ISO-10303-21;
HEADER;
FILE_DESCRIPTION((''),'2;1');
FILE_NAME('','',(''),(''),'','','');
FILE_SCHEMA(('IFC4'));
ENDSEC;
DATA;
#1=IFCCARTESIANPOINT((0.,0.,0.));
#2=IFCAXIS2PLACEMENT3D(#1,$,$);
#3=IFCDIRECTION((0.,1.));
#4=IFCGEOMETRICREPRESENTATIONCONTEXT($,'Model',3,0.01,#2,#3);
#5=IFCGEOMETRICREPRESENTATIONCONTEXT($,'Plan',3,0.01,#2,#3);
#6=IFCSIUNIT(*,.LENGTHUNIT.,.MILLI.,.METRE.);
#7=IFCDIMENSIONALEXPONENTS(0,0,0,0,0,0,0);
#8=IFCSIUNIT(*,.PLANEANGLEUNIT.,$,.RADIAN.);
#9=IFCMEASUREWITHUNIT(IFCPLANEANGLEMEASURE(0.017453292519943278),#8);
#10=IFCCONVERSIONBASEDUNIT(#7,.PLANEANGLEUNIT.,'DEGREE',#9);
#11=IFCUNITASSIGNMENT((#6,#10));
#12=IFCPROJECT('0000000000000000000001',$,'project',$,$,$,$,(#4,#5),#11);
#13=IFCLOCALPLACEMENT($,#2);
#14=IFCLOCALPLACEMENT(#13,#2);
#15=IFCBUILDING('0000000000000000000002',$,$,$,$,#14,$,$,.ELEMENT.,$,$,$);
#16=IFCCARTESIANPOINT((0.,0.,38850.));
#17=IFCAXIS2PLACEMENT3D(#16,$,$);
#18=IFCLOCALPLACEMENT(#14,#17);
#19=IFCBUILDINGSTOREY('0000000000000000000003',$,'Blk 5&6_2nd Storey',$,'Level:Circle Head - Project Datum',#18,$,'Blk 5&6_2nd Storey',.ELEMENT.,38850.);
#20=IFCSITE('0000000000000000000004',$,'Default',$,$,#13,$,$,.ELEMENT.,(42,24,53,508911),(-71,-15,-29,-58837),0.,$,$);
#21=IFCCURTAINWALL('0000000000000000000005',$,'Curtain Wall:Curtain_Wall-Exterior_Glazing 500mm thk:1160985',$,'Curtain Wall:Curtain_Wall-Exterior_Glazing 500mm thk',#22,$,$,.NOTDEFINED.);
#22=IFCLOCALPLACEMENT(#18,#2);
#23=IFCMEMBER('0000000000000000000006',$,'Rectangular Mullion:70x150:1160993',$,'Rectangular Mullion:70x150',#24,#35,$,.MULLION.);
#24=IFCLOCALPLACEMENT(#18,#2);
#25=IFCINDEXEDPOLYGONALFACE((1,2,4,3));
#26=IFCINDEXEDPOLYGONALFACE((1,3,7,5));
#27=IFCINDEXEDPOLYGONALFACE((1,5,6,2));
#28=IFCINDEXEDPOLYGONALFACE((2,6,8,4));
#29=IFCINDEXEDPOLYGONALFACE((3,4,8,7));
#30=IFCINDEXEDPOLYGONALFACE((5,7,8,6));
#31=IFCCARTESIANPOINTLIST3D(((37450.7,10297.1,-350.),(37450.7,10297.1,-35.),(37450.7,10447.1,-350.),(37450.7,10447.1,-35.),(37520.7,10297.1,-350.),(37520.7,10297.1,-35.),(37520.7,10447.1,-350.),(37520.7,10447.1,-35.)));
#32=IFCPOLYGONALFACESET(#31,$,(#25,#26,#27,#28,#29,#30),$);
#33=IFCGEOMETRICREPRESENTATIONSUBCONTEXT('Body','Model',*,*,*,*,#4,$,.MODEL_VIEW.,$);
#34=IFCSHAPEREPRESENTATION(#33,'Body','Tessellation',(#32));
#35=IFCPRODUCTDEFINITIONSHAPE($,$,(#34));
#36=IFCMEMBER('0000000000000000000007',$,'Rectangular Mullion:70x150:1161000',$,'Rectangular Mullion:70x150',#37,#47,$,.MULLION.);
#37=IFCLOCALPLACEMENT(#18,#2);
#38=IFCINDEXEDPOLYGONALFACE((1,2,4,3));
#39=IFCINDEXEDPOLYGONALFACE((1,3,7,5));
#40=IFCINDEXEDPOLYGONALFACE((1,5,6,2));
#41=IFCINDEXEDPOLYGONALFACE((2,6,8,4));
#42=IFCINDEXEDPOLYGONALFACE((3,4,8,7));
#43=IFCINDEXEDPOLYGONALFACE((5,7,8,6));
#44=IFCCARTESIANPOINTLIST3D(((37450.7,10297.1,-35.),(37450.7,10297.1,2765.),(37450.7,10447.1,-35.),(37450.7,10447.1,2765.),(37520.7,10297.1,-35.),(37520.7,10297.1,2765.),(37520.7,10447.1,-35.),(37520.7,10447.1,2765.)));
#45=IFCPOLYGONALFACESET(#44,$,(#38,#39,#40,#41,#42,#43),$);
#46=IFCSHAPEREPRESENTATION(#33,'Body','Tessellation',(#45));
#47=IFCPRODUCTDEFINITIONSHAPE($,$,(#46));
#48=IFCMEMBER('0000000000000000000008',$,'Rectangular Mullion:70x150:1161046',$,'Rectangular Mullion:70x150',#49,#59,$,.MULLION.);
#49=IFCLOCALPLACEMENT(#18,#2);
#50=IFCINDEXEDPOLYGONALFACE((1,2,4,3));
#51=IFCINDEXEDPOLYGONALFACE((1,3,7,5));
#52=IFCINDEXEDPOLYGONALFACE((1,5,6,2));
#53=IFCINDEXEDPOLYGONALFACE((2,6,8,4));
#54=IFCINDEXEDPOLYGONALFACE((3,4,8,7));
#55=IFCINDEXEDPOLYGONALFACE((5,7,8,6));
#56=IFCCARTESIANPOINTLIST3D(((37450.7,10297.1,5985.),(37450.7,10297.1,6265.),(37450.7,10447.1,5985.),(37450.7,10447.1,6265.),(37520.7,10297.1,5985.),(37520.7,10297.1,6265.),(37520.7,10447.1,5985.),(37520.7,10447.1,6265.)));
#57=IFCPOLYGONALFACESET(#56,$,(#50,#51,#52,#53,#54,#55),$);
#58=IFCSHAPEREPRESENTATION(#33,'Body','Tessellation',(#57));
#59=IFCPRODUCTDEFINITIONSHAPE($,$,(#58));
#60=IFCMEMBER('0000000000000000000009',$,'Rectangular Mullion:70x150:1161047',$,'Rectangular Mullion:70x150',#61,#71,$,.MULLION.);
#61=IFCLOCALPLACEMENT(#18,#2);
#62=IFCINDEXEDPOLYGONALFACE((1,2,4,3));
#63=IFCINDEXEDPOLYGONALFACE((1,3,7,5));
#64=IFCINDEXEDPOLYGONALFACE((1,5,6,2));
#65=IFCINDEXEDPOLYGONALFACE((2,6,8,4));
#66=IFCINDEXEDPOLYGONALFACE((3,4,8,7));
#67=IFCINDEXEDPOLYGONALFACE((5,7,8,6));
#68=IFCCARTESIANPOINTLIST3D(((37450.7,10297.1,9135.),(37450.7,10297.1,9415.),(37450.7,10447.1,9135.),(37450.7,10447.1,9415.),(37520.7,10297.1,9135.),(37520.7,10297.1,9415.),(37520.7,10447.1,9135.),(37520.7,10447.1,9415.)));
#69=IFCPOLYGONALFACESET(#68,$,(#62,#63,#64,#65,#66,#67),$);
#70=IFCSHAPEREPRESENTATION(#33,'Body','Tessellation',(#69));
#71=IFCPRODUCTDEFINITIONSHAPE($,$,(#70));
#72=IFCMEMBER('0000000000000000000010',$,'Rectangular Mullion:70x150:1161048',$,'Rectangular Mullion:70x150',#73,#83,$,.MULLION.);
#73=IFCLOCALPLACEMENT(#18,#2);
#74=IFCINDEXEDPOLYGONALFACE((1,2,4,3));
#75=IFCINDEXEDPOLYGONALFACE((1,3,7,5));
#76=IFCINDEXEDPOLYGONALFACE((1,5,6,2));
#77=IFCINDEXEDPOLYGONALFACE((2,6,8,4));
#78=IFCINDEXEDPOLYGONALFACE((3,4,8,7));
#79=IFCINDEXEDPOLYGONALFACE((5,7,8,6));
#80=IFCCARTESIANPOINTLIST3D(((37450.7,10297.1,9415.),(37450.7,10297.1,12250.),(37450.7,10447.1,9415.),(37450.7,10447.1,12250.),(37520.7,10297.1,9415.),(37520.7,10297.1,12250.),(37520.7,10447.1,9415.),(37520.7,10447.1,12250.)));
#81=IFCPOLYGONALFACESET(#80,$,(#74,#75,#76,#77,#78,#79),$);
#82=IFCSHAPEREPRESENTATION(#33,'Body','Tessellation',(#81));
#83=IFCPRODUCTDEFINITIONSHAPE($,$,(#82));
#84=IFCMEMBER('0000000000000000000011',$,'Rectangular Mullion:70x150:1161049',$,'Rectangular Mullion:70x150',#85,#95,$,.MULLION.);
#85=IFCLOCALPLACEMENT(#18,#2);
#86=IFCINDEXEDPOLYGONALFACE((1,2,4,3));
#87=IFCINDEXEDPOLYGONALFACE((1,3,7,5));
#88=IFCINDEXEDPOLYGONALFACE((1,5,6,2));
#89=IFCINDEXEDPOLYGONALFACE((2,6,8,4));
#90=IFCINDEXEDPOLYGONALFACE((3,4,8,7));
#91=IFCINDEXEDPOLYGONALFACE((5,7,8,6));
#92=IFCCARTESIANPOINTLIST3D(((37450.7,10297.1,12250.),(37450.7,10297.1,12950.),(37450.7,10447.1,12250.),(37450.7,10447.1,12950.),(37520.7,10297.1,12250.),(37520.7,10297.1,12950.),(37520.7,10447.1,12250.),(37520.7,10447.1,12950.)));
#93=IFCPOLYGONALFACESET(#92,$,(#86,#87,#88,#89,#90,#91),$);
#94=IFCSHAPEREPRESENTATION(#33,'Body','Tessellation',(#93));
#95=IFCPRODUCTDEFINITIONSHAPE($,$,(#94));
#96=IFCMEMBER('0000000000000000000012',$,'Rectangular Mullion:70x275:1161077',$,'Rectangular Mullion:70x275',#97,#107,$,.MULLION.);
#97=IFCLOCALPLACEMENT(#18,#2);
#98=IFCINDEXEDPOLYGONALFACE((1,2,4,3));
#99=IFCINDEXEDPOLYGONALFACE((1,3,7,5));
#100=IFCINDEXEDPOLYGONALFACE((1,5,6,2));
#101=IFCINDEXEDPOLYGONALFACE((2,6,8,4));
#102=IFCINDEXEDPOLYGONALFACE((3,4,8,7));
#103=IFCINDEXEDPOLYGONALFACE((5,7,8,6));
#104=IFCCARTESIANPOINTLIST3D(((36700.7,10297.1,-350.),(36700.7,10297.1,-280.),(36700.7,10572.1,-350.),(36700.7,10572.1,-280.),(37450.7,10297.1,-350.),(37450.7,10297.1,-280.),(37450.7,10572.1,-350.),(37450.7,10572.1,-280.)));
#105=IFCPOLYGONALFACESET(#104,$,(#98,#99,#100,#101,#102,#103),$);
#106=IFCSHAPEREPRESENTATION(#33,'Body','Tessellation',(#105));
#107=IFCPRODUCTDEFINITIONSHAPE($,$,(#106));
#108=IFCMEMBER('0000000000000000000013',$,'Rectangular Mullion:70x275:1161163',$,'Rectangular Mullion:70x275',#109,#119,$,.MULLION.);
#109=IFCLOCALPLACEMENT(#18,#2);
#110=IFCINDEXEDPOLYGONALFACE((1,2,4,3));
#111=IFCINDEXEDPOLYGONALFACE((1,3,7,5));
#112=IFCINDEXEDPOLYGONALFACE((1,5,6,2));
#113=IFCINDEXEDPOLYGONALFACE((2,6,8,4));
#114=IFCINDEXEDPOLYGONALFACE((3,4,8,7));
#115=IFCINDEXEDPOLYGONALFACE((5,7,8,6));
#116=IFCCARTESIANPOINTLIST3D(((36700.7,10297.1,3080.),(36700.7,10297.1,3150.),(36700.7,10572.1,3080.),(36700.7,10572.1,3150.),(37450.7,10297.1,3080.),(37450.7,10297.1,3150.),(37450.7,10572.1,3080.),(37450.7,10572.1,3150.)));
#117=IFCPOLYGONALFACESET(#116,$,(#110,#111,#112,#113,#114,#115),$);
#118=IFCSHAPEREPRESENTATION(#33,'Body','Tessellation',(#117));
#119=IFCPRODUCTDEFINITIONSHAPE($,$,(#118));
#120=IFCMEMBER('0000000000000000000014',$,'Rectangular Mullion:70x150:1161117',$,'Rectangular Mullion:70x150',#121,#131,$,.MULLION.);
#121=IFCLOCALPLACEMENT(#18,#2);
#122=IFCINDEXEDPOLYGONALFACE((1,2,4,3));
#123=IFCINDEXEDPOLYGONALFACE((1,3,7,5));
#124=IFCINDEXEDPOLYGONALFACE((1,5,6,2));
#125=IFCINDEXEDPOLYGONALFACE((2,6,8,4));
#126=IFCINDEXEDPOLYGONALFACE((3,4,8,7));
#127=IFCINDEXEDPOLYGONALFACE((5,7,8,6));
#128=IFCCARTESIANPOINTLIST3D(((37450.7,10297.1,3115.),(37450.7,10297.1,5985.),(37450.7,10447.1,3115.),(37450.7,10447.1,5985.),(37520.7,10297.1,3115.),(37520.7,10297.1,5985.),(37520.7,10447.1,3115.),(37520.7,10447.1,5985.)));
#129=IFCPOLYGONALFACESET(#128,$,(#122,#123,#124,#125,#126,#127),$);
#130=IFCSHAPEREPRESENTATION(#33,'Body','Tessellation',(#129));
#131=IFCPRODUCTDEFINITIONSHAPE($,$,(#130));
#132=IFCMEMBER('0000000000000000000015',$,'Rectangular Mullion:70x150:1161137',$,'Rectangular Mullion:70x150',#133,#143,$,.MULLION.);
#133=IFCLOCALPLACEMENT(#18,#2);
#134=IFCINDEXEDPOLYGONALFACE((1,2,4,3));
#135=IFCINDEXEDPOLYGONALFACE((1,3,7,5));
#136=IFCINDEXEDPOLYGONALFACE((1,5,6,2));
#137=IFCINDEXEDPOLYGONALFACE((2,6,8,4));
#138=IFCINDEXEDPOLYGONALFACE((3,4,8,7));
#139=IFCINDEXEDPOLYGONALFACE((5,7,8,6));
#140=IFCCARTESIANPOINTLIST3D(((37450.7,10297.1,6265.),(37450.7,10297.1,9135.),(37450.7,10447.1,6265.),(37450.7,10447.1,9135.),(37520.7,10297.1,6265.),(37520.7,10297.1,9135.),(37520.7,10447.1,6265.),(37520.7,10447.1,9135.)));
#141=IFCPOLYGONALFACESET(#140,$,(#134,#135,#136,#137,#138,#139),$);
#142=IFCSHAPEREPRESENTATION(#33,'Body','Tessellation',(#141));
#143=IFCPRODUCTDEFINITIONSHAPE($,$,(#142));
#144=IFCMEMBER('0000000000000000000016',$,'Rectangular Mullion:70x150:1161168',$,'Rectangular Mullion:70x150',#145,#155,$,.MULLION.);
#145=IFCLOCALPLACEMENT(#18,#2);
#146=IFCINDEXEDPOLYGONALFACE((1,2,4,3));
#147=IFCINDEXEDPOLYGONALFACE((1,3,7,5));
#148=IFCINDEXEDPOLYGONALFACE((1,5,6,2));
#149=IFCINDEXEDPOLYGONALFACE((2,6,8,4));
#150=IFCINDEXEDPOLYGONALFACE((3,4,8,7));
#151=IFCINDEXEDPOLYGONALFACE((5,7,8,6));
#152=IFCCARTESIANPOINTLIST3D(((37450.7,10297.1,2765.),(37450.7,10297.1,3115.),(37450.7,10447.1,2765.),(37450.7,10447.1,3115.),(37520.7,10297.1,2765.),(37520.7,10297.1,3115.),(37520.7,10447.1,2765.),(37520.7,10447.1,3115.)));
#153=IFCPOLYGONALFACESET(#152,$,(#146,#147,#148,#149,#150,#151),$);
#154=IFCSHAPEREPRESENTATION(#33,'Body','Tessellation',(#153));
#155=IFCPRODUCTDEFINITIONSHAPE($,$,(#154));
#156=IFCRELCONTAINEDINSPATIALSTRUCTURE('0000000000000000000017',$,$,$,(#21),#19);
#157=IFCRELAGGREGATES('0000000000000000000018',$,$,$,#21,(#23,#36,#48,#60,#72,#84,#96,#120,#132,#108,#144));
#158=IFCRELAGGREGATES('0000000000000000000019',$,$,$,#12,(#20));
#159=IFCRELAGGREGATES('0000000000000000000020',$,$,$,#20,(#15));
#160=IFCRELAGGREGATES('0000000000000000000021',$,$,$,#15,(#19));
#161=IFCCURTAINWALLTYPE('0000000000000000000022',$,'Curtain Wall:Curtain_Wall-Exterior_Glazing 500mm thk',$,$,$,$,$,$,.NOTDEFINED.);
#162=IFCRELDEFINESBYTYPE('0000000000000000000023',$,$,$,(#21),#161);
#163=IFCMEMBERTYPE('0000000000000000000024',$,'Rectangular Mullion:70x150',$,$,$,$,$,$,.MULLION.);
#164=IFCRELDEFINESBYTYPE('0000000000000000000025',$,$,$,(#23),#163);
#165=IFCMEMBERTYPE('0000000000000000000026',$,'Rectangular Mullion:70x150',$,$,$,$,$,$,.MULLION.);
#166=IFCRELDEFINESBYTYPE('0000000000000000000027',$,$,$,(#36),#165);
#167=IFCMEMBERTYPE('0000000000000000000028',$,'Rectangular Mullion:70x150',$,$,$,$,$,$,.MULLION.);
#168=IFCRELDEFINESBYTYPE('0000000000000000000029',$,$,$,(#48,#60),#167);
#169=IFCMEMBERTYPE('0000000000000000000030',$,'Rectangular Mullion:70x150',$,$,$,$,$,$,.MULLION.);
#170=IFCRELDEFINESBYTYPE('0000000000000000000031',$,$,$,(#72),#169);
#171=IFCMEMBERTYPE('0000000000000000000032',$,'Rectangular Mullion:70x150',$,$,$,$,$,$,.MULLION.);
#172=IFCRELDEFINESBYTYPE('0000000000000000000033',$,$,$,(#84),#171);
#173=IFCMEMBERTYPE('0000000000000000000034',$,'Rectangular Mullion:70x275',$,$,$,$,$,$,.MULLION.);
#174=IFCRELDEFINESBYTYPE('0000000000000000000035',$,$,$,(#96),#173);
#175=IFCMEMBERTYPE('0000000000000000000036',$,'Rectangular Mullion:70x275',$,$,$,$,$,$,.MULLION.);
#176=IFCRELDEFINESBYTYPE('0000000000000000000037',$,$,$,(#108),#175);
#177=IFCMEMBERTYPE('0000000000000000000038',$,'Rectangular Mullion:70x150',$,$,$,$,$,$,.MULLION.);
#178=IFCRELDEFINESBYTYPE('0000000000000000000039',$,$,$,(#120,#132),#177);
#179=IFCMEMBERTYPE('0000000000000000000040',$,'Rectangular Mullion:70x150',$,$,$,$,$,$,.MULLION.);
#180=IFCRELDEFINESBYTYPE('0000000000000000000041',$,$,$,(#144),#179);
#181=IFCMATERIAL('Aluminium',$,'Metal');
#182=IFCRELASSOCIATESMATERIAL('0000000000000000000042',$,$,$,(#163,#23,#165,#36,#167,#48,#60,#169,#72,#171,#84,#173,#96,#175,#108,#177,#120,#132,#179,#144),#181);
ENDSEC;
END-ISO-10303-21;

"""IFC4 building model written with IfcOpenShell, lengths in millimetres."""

from ifc_helpers import new_model, entity, si_unit, converted_unit, direction, frame, origin, place, context, subcontext, project, spatial, indexed_curve, outline, extrude, source, transform, mapped, material, type_object, type_shapes, element, aggregate, save


model = new_model("IFC4")

# Units and contexts
model_context = context("Model", 3, precision=0.01, world=origin(), true_north=direction((0.0, 1.0)))
plan_context = context("Plan", 3, precision=0.01, world=origin(), true_north=direction((0.0, 1.0)))
body_context = subcontext(model_context, "Body", "Model", "MODEL_VIEW")
ifc_project = project(units=[si_unit("LENGTHUNIT", "METRE", prefix="MILLI"), converted_unit("PLANEANGLEUNIT", "DEGREE", entity("IfcPlaneAngleMeasure", 0.017453292519943278), si_unit("PLANEANGLEUNIT", "RADIAN"), dimensions=[0, 0, 0, 0, 0, 0, 0])], contexts=[model_context, plan_context])

# Site, building, storey
site_placement = place(None, origin())
site = spatial("IfcSite", under=ifc_project, at=site_placement, Name="Default", CompositionType="ELEMENT", RefLatitude=(42, 24, 53, 508911), RefLongitude=(-71, -15, -29, -58837), RefElevation=0.0)
building_placement = place(site_placement, origin())
building = spatial("IfcBuilding", under=site, at=building_placement, CompositionType="ELEMENT")
storey_placement = place(building_placement, frame((0.0, 0.0, 38850.0)))
storey = spatial("IfcBuildingStorey", under=building, at=storey_placement, Name="Blk 5&6_2nd Storey", ObjectType="Level:Circle Head - Project Datum", LongName="Blk 5&6_2nd Storey", CompositionType="ELEMENT", Elevation=38850.0)

# Curtain wall, members
curtain_wall_type = type_object("IfcCurtainWallType", Name="Curtain Wall:Curtain_Wall-Exterior_Glazing 500mm thk", PredefinedType="NOTDEFINED")
curtain_wall_placement = place(storey_placement, frame((0.0, 0.0, -38850.0)))
curtain_wall = element("IfcCurtainWall", 1, at=curtain_wall_placement, inside=storey, type_object=curtain_wall_type, Name="Curtain Wall:Curtain_Wall-Exterior_Glazing 500mm thk:1160985", ObjectType="Curtain Wall:Curtain_Wall-Exterior_Glazing 500mm thk", PredefinedType="NOTDEFINED")
ifc_material_1 = material(Name="Aluminium", Category="Metal")
member_type_1 = type_object("IfcMemberType", Name="Rectangular Mullion:70x150", PredefinedType="MULLION", material=ifc_material_1)
shared_shape_1 = source(origin(), body_context, "Body", "SweptSolid", [
    extrude(outline(indexed_curve([(-35.0, -75.0), (35.0, -75.0), (35.0, 75.0), (-35.0, 75.0), (-35.0, -75.0)], self_intersect=False)), frame((0.0, -200.0, -315.0), z_axis=(0.0, 0.0, 1.0), x_axis=(-1.0, 0.0, 0.0)), (0.0, 0.0, 1.0), 315.0),
])
type_shapes(member_type_1, [shared_shape_1])
member_1_placement = place(curtain_wall_placement, frame((37485.7, 10572.1, 38500.0), z_axis=(0.0, 0.0, -1.0), x_axis=(-1.0, 0.0, 0.0)))
member_1 = element("IfcMember", 2, at=member_1_placement, type_object=member_type_1, material=ifc_material_1, Name="Rectangular Mullion:70x150:1160993", ObjectType="Rectangular Mullion:70x150", PredefinedType="MULLION", context=body_context, shape_type="MappedRepresentation", body=[
    mapped(shared_shape_1, transform((0.0, 0.0, 0.0), scale=1.0)),
])
member_type_2 = type_object("IfcMemberType", Name="Rectangular Mullion:70x150", PredefinedType="MULLION", material=ifc_material_1)
shared_shape_2 = source(origin(), body_context, "Body", "SweptSolid", [
    extrude(outline(indexed_curve([(-35.0, -75.0), (35.0, -75.0), (35.0, 75.0), (-35.0, 75.0), (-35.0, -75.0)], self_intersect=False)), frame((0.0, -200.0, -2800.0), z_axis=(0.0, 0.0, 1.0), x_axis=(-1.0, 0.0, 0.0)), (0.0, 0.0, 1.0), 2800.0),
])
type_shapes(member_type_2, [shared_shape_2])
member_2_placement = place(curtain_wall_placement, frame((37485.7, 10572.1, 38815.0), z_axis=(0.0, 0.0, -1.0), x_axis=(-1.0, 0.0, 0.0)))
member_2 = element("IfcMember", 3, at=member_2_placement, type_object=member_type_2, material=ifc_material_1, Name="Rectangular Mullion:70x150:1161000", ObjectType="Rectangular Mullion:70x150", PredefinedType="MULLION", context=body_context, shape_type="MappedRepresentation", body=[
    mapped(shared_shape_2, transform((0.0, 0.0, 0.0), scale=1.0)),
])
member_type_3 = type_object("IfcMemberType", Name="Rectangular Mullion:70x150", PredefinedType="MULLION", material=ifc_material_1)
shared_shape_3 = source(origin(), body_context, "Body", "SweptSolid", [
    extrude(outline(indexed_curve([(-35.0, -75.0), (35.0, -75.0), (35.0, 75.0), (-35.0, 75.0), (-35.0, -75.0)], self_intersect=False)), frame((0.0, -200.0, -280.0), z_axis=(0.0, 0.0, 1.0), x_axis=(-1.0, 0.0, 0.0)), (0.0, 0.0, 1.0), 280.0),
])
type_shapes(member_type_3, [shared_shape_3])
member_3_placement = place(curtain_wall_placement, frame((37485.7, 10572.1, 44835.0), z_axis=(0.0, 0.0, -1.0), x_axis=(-1.0, 0.0, 0.0)))
member_3 = element("IfcMember", 4, at=member_3_placement, type_object=member_type_3, material=ifc_material_1, Name="Rectangular Mullion:70x150:1161046", ObjectType="Rectangular Mullion:70x150", PredefinedType="MULLION", context=body_context, shape_type="MappedRepresentation", body=[
    mapped(shared_shape_3, transform((0.0, 0.0, 0.0), scale=1.0)),
])
member_4_placement = place(curtain_wall_placement, frame((37485.7, 10572.1, 47985.0), z_axis=(0.0, 0.0, -1.0), x_axis=(-1.0, 0.0, 0.0)))
member_4 = element("IfcMember", 5, at=member_4_placement, type_object=member_type_3, material=ifc_material_1, Name="Rectangular Mullion:70x150:1161047", ObjectType="Rectangular Mullion:70x150", PredefinedType="MULLION", context=body_context, shape_type="MappedRepresentation", body=[
    mapped(shared_shape_3, transform((0.0, 0.0, 0.0), scale=1.0)),
])
member_type_4 = type_object("IfcMemberType", Name="Rectangular Mullion:70x150", PredefinedType="MULLION", material=ifc_material_1)
shared_shape_4 = source(origin(), body_context, "Body", "SweptSolid", [
    extrude(outline(indexed_curve([(-35.0, -75.0), (35.0, -75.0), (35.0, 75.0), (-35.0, 75.0), (-35.0, -75.0)], self_intersect=False)), frame((0.0, -200.0, -2835.0), z_axis=(0.0, 0.0, 1.0), x_axis=(-1.0, 0.0, 0.0)), (0.0, 0.0, 1.0), 2835.0),
])
type_shapes(member_type_4, [shared_shape_4])
member_5_placement = place(curtain_wall_placement, frame((37485.7, 10572.1, 48265.0), z_axis=(0.0, 0.0, -1.0), x_axis=(-1.0, 0.0, 0.0)))
member_5 = element("IfcMember", 6, at=member_5_placement, type_object=member_type_4, material=ifc_material_1, Name="Rectangular Mullion:70x150:1161048", ObjectType="Rectangular Mullion:70x150", PredefinedType="MULLION", context=body_context, shape_type="MappedRepresentation", body=[
    mapped(shared_shape_4, transform((0.0, 0.0, 0.0), scale=1.0)),
])
member_type_5 = type_object("IfcMemberType", Name="Rectangular Mullion:70x150", PredefinedType="MULLION", material=ifc_material_1)
shared_shape_5 = source(origin(), body_context, "Body", "SweptSolid", [
    extrude(outline(indexed_curve([(-35.0, -75.0), (35.0, -75.0), (35.0, 75.0), (-35.0, 75.0), (-35.0, -75.0)], self_intersect=False)), frame((0.0, -200.0, -700.0), z_axis=(0.0, 0.0, 1.0), x_axis=(-1.0, 0.0, 0.0)), (0.0, 0.0, 1.0), 700.0),
])
type_shapes(member_type_5, [shared_shape_5])
member_6_placement = place(curtain_wall_placement, frame((37485.7, 10572.1, 51100.0), z_axis=(0.0, 0.0, -1.0), x_axis=(-1.0, 0.0, 0.0)))
member_6 = element("IfcMember", 7, at=member_6_placement, type_object=member_type_5, material=ifc_material_1, Name="Rectangular Mullion:70x150:1161049", ObjectType="Rectangular Mullion:70x150", PredefinedType="MULLION", context=body_context, shape_type="MappedRepresentation", body=[
    mapped(shared_shape_5, transform((0.0, 0.0, 0.0), scale=1.0)),
])
member_type_6 = type_object("IfcMemberType", Name="Rectangular Mullion:70x275", PredefinedType="MULLION", material=ifc_material_1)
shared_shape_6 = source(origin(), body_context, "Body", "SweptSolid", [
    extrude(outline(indexed_curve([(-35.0, -137.5), (35.0, -137.5), (35.0, 137.5), (-35.0, 137.5), (-35.0, -137.5)], self_intersect=False)), frame((-35.0, -137.5, -750.0), z_axis=(0.0, 0.0, 1.0), x_axis=(-1.0, 0.0, 0.0)), (0.0, 0.0, 1.0), 750.0),
])
type_shapes(member_type_6, [shared_shape_6])
member_7_placement = place(curtain_wall_placement, frame((37450.7, 10572.1, 38500.0), z_axis=(1.0, 0.0, 0.0), x_axis=(0.0, 0.0, -1.0)))
member_7 = element("IfcMember", 8, at=member_7_placement, type_object=member_type_6, material=ifc_material_1, Name="Rectangular Mullion:70x275:1161077", ObjectType="Rectangular Mullion:70x275", PredefinedType="MULLION", context=body_context, shape_type="MappedRepresentation", body=[
    mapped(shared_shape_6, transform((0.0, 0.0, 0.0), scale=1.0)),
])
member_type_7 = type_object("IfcMemberType", Name="Rectangular Mullion:70x275", PredefinedType="MULLION", material=ifc_material_1)
shared_shape_7 = source(origin(), body_context, "Body", "SweptSolid", [
    extrude(outline(indexed_curve([(-35.0, -137.5), (35.0, -137.5), (35.0, 137.5), (-35.0, 137.5), (-35.0, -137.5)], self_intersect=False)), frame((0.0, -137.5, -750.0), z_axis=(0.0, 0.0, 1.0), x_axis=(-1.0, 0.0, 0.0)), (0.0, 0.0, 1.0), 750.0),
])
type_shapes(member_type_7, [shared_shape_7])
member_8_placement = place(curtain_wall_placement, frame((36700.7, 10572.1, 41965.0), z_axis=(-1.0, 0.0, 0.0), x_axis=(0.0, 0.0, 1.0)))
member_8 = element("IfcMember", 9, at=member_8_placement, type_object=member_type_7, material=ifc_material_1, Name="Rectangular Mullion:70x275:1161163", ObjectType="Rectangular Mullion:70x275", PredefinedType="MULLION", context=body_context, shape_type="MappedRepresentation", body=[
    mapped(shared_shape_7, transform((0.0, 0.0, 0.0), scale=1.0)),
])
member_type_8 = type_object("IfcMemberType", Name="Rectangular Mullion:70x150", PredefinedType="MULLION", material=ifc_material_1)
shared_shape_8 = source(origin(), body_context, "Body", "SweptSolid", [
    extrude(outline(indexed_curve([(-35.0, -75.0), (35.0, -75.0), (35.0, 75.0), (-35.0, 75.0), (-35.0, -75.0)], self_intersect=False)), frame((0.0, -200.0, -2870.0), z_axis=(0.0, 0.0, 1.0), x_axis=(-1.0, 0.0, 0.0)), (0.0, 0.0, 1.0), 2870.0),
])
type_shapes(member_type_8, [shared_shape_8])
member_9_placement = place(curtain_wall_placement, frame((37485.7, 10572.1, 41965.0), z_axis=(0.0, 0.0, -1.0), x_axis=(-1.0, 0.0, 0.0)))
member_9 = element("IfcMember", 10, at=member_9_placement, type_object=member_type_8, material=ifc_material_1, Name="Rectangular Mullion:70x150:1161117", ObjectType="Rectangular Mullion:70x150", PredefinedType="MULLION", context=body_context, shape_type="MappedRepresentation", body=[
    mapped(shared_shape_8, transform((0.0, 0.0, 0.0), scale=1.0)),
])
member_10_placement = place(curtain_wall_placement, frame((37485.7, 10572.1, 45115.0), z_axis=(0.0, 0.0, -1.0), x_axis=(-1.0, 0.0, 0.0)))
member_10 = element("IfcMember", 11, at=member_10_placement, type_object=member_type_8, material=ifc_material_1, Name="Rectangular Mullion:70x150:1161137", ObjectType="Rectangular Mullion:70x150", PredefinedType="MULLION", context=body_context, shape_type="MappedRepresentation", body=[
    mapped(shared_shape_8, transform((0.0, 0.0, 0.0), scale=1.0)),
])
member_type_9 = type_object("IfcMemberType", Name="Rectangular Mullion:70x150", PredefinedType="MULLION", material=ifc_material_1)
shared_shape_9 = source(origin(), body_context, "Body", "SweptSolid", [
    extrude(outline(indexed_curve([(-35.0, -75.0), (35.0, -75.0), (35.0, 75.0), (-35.0, 75.0), (-35.0, -75.0)], self_intersect=False)), frame((0.0, -200.0, -350.0), z_axis=(0.0, 0.0, 1.0), x_axis=(-1.0, 0.0, 0.0)), (0.0, 0.0, 1.0), 350.0),
])
type_shapes(member_type_9, [shared_shape_9])
member_11_placement = place(curtain_wall_placement, frame((37485.7, 10572.1, 41615.0), z_axis=(0.0, 0.0, -1.0), x_axis=(-1.0, 0.0, 0.0)))
member_11 = element("IfcMember", 12, at=member_11_placement, type_object=member_type_9, material=ifc_material_1, Name="Rectangular Mullion:70x150:1161168", ObjectType="Rectangular Mullion:70x150", PredefinedType="MULLION", context=body_context, shape_type="MappedRepresentation", body=[
    mapped(shared_shape_9, transform((0.0, 0.0, 0.0), scale=1.0)),
])
aggregate(curtain_wall, [member_1, member_2, member_3, member_4, member_5, member_6, member_7, member_9, member_10, member_8, member_11])

save(model, "model.ifc")
